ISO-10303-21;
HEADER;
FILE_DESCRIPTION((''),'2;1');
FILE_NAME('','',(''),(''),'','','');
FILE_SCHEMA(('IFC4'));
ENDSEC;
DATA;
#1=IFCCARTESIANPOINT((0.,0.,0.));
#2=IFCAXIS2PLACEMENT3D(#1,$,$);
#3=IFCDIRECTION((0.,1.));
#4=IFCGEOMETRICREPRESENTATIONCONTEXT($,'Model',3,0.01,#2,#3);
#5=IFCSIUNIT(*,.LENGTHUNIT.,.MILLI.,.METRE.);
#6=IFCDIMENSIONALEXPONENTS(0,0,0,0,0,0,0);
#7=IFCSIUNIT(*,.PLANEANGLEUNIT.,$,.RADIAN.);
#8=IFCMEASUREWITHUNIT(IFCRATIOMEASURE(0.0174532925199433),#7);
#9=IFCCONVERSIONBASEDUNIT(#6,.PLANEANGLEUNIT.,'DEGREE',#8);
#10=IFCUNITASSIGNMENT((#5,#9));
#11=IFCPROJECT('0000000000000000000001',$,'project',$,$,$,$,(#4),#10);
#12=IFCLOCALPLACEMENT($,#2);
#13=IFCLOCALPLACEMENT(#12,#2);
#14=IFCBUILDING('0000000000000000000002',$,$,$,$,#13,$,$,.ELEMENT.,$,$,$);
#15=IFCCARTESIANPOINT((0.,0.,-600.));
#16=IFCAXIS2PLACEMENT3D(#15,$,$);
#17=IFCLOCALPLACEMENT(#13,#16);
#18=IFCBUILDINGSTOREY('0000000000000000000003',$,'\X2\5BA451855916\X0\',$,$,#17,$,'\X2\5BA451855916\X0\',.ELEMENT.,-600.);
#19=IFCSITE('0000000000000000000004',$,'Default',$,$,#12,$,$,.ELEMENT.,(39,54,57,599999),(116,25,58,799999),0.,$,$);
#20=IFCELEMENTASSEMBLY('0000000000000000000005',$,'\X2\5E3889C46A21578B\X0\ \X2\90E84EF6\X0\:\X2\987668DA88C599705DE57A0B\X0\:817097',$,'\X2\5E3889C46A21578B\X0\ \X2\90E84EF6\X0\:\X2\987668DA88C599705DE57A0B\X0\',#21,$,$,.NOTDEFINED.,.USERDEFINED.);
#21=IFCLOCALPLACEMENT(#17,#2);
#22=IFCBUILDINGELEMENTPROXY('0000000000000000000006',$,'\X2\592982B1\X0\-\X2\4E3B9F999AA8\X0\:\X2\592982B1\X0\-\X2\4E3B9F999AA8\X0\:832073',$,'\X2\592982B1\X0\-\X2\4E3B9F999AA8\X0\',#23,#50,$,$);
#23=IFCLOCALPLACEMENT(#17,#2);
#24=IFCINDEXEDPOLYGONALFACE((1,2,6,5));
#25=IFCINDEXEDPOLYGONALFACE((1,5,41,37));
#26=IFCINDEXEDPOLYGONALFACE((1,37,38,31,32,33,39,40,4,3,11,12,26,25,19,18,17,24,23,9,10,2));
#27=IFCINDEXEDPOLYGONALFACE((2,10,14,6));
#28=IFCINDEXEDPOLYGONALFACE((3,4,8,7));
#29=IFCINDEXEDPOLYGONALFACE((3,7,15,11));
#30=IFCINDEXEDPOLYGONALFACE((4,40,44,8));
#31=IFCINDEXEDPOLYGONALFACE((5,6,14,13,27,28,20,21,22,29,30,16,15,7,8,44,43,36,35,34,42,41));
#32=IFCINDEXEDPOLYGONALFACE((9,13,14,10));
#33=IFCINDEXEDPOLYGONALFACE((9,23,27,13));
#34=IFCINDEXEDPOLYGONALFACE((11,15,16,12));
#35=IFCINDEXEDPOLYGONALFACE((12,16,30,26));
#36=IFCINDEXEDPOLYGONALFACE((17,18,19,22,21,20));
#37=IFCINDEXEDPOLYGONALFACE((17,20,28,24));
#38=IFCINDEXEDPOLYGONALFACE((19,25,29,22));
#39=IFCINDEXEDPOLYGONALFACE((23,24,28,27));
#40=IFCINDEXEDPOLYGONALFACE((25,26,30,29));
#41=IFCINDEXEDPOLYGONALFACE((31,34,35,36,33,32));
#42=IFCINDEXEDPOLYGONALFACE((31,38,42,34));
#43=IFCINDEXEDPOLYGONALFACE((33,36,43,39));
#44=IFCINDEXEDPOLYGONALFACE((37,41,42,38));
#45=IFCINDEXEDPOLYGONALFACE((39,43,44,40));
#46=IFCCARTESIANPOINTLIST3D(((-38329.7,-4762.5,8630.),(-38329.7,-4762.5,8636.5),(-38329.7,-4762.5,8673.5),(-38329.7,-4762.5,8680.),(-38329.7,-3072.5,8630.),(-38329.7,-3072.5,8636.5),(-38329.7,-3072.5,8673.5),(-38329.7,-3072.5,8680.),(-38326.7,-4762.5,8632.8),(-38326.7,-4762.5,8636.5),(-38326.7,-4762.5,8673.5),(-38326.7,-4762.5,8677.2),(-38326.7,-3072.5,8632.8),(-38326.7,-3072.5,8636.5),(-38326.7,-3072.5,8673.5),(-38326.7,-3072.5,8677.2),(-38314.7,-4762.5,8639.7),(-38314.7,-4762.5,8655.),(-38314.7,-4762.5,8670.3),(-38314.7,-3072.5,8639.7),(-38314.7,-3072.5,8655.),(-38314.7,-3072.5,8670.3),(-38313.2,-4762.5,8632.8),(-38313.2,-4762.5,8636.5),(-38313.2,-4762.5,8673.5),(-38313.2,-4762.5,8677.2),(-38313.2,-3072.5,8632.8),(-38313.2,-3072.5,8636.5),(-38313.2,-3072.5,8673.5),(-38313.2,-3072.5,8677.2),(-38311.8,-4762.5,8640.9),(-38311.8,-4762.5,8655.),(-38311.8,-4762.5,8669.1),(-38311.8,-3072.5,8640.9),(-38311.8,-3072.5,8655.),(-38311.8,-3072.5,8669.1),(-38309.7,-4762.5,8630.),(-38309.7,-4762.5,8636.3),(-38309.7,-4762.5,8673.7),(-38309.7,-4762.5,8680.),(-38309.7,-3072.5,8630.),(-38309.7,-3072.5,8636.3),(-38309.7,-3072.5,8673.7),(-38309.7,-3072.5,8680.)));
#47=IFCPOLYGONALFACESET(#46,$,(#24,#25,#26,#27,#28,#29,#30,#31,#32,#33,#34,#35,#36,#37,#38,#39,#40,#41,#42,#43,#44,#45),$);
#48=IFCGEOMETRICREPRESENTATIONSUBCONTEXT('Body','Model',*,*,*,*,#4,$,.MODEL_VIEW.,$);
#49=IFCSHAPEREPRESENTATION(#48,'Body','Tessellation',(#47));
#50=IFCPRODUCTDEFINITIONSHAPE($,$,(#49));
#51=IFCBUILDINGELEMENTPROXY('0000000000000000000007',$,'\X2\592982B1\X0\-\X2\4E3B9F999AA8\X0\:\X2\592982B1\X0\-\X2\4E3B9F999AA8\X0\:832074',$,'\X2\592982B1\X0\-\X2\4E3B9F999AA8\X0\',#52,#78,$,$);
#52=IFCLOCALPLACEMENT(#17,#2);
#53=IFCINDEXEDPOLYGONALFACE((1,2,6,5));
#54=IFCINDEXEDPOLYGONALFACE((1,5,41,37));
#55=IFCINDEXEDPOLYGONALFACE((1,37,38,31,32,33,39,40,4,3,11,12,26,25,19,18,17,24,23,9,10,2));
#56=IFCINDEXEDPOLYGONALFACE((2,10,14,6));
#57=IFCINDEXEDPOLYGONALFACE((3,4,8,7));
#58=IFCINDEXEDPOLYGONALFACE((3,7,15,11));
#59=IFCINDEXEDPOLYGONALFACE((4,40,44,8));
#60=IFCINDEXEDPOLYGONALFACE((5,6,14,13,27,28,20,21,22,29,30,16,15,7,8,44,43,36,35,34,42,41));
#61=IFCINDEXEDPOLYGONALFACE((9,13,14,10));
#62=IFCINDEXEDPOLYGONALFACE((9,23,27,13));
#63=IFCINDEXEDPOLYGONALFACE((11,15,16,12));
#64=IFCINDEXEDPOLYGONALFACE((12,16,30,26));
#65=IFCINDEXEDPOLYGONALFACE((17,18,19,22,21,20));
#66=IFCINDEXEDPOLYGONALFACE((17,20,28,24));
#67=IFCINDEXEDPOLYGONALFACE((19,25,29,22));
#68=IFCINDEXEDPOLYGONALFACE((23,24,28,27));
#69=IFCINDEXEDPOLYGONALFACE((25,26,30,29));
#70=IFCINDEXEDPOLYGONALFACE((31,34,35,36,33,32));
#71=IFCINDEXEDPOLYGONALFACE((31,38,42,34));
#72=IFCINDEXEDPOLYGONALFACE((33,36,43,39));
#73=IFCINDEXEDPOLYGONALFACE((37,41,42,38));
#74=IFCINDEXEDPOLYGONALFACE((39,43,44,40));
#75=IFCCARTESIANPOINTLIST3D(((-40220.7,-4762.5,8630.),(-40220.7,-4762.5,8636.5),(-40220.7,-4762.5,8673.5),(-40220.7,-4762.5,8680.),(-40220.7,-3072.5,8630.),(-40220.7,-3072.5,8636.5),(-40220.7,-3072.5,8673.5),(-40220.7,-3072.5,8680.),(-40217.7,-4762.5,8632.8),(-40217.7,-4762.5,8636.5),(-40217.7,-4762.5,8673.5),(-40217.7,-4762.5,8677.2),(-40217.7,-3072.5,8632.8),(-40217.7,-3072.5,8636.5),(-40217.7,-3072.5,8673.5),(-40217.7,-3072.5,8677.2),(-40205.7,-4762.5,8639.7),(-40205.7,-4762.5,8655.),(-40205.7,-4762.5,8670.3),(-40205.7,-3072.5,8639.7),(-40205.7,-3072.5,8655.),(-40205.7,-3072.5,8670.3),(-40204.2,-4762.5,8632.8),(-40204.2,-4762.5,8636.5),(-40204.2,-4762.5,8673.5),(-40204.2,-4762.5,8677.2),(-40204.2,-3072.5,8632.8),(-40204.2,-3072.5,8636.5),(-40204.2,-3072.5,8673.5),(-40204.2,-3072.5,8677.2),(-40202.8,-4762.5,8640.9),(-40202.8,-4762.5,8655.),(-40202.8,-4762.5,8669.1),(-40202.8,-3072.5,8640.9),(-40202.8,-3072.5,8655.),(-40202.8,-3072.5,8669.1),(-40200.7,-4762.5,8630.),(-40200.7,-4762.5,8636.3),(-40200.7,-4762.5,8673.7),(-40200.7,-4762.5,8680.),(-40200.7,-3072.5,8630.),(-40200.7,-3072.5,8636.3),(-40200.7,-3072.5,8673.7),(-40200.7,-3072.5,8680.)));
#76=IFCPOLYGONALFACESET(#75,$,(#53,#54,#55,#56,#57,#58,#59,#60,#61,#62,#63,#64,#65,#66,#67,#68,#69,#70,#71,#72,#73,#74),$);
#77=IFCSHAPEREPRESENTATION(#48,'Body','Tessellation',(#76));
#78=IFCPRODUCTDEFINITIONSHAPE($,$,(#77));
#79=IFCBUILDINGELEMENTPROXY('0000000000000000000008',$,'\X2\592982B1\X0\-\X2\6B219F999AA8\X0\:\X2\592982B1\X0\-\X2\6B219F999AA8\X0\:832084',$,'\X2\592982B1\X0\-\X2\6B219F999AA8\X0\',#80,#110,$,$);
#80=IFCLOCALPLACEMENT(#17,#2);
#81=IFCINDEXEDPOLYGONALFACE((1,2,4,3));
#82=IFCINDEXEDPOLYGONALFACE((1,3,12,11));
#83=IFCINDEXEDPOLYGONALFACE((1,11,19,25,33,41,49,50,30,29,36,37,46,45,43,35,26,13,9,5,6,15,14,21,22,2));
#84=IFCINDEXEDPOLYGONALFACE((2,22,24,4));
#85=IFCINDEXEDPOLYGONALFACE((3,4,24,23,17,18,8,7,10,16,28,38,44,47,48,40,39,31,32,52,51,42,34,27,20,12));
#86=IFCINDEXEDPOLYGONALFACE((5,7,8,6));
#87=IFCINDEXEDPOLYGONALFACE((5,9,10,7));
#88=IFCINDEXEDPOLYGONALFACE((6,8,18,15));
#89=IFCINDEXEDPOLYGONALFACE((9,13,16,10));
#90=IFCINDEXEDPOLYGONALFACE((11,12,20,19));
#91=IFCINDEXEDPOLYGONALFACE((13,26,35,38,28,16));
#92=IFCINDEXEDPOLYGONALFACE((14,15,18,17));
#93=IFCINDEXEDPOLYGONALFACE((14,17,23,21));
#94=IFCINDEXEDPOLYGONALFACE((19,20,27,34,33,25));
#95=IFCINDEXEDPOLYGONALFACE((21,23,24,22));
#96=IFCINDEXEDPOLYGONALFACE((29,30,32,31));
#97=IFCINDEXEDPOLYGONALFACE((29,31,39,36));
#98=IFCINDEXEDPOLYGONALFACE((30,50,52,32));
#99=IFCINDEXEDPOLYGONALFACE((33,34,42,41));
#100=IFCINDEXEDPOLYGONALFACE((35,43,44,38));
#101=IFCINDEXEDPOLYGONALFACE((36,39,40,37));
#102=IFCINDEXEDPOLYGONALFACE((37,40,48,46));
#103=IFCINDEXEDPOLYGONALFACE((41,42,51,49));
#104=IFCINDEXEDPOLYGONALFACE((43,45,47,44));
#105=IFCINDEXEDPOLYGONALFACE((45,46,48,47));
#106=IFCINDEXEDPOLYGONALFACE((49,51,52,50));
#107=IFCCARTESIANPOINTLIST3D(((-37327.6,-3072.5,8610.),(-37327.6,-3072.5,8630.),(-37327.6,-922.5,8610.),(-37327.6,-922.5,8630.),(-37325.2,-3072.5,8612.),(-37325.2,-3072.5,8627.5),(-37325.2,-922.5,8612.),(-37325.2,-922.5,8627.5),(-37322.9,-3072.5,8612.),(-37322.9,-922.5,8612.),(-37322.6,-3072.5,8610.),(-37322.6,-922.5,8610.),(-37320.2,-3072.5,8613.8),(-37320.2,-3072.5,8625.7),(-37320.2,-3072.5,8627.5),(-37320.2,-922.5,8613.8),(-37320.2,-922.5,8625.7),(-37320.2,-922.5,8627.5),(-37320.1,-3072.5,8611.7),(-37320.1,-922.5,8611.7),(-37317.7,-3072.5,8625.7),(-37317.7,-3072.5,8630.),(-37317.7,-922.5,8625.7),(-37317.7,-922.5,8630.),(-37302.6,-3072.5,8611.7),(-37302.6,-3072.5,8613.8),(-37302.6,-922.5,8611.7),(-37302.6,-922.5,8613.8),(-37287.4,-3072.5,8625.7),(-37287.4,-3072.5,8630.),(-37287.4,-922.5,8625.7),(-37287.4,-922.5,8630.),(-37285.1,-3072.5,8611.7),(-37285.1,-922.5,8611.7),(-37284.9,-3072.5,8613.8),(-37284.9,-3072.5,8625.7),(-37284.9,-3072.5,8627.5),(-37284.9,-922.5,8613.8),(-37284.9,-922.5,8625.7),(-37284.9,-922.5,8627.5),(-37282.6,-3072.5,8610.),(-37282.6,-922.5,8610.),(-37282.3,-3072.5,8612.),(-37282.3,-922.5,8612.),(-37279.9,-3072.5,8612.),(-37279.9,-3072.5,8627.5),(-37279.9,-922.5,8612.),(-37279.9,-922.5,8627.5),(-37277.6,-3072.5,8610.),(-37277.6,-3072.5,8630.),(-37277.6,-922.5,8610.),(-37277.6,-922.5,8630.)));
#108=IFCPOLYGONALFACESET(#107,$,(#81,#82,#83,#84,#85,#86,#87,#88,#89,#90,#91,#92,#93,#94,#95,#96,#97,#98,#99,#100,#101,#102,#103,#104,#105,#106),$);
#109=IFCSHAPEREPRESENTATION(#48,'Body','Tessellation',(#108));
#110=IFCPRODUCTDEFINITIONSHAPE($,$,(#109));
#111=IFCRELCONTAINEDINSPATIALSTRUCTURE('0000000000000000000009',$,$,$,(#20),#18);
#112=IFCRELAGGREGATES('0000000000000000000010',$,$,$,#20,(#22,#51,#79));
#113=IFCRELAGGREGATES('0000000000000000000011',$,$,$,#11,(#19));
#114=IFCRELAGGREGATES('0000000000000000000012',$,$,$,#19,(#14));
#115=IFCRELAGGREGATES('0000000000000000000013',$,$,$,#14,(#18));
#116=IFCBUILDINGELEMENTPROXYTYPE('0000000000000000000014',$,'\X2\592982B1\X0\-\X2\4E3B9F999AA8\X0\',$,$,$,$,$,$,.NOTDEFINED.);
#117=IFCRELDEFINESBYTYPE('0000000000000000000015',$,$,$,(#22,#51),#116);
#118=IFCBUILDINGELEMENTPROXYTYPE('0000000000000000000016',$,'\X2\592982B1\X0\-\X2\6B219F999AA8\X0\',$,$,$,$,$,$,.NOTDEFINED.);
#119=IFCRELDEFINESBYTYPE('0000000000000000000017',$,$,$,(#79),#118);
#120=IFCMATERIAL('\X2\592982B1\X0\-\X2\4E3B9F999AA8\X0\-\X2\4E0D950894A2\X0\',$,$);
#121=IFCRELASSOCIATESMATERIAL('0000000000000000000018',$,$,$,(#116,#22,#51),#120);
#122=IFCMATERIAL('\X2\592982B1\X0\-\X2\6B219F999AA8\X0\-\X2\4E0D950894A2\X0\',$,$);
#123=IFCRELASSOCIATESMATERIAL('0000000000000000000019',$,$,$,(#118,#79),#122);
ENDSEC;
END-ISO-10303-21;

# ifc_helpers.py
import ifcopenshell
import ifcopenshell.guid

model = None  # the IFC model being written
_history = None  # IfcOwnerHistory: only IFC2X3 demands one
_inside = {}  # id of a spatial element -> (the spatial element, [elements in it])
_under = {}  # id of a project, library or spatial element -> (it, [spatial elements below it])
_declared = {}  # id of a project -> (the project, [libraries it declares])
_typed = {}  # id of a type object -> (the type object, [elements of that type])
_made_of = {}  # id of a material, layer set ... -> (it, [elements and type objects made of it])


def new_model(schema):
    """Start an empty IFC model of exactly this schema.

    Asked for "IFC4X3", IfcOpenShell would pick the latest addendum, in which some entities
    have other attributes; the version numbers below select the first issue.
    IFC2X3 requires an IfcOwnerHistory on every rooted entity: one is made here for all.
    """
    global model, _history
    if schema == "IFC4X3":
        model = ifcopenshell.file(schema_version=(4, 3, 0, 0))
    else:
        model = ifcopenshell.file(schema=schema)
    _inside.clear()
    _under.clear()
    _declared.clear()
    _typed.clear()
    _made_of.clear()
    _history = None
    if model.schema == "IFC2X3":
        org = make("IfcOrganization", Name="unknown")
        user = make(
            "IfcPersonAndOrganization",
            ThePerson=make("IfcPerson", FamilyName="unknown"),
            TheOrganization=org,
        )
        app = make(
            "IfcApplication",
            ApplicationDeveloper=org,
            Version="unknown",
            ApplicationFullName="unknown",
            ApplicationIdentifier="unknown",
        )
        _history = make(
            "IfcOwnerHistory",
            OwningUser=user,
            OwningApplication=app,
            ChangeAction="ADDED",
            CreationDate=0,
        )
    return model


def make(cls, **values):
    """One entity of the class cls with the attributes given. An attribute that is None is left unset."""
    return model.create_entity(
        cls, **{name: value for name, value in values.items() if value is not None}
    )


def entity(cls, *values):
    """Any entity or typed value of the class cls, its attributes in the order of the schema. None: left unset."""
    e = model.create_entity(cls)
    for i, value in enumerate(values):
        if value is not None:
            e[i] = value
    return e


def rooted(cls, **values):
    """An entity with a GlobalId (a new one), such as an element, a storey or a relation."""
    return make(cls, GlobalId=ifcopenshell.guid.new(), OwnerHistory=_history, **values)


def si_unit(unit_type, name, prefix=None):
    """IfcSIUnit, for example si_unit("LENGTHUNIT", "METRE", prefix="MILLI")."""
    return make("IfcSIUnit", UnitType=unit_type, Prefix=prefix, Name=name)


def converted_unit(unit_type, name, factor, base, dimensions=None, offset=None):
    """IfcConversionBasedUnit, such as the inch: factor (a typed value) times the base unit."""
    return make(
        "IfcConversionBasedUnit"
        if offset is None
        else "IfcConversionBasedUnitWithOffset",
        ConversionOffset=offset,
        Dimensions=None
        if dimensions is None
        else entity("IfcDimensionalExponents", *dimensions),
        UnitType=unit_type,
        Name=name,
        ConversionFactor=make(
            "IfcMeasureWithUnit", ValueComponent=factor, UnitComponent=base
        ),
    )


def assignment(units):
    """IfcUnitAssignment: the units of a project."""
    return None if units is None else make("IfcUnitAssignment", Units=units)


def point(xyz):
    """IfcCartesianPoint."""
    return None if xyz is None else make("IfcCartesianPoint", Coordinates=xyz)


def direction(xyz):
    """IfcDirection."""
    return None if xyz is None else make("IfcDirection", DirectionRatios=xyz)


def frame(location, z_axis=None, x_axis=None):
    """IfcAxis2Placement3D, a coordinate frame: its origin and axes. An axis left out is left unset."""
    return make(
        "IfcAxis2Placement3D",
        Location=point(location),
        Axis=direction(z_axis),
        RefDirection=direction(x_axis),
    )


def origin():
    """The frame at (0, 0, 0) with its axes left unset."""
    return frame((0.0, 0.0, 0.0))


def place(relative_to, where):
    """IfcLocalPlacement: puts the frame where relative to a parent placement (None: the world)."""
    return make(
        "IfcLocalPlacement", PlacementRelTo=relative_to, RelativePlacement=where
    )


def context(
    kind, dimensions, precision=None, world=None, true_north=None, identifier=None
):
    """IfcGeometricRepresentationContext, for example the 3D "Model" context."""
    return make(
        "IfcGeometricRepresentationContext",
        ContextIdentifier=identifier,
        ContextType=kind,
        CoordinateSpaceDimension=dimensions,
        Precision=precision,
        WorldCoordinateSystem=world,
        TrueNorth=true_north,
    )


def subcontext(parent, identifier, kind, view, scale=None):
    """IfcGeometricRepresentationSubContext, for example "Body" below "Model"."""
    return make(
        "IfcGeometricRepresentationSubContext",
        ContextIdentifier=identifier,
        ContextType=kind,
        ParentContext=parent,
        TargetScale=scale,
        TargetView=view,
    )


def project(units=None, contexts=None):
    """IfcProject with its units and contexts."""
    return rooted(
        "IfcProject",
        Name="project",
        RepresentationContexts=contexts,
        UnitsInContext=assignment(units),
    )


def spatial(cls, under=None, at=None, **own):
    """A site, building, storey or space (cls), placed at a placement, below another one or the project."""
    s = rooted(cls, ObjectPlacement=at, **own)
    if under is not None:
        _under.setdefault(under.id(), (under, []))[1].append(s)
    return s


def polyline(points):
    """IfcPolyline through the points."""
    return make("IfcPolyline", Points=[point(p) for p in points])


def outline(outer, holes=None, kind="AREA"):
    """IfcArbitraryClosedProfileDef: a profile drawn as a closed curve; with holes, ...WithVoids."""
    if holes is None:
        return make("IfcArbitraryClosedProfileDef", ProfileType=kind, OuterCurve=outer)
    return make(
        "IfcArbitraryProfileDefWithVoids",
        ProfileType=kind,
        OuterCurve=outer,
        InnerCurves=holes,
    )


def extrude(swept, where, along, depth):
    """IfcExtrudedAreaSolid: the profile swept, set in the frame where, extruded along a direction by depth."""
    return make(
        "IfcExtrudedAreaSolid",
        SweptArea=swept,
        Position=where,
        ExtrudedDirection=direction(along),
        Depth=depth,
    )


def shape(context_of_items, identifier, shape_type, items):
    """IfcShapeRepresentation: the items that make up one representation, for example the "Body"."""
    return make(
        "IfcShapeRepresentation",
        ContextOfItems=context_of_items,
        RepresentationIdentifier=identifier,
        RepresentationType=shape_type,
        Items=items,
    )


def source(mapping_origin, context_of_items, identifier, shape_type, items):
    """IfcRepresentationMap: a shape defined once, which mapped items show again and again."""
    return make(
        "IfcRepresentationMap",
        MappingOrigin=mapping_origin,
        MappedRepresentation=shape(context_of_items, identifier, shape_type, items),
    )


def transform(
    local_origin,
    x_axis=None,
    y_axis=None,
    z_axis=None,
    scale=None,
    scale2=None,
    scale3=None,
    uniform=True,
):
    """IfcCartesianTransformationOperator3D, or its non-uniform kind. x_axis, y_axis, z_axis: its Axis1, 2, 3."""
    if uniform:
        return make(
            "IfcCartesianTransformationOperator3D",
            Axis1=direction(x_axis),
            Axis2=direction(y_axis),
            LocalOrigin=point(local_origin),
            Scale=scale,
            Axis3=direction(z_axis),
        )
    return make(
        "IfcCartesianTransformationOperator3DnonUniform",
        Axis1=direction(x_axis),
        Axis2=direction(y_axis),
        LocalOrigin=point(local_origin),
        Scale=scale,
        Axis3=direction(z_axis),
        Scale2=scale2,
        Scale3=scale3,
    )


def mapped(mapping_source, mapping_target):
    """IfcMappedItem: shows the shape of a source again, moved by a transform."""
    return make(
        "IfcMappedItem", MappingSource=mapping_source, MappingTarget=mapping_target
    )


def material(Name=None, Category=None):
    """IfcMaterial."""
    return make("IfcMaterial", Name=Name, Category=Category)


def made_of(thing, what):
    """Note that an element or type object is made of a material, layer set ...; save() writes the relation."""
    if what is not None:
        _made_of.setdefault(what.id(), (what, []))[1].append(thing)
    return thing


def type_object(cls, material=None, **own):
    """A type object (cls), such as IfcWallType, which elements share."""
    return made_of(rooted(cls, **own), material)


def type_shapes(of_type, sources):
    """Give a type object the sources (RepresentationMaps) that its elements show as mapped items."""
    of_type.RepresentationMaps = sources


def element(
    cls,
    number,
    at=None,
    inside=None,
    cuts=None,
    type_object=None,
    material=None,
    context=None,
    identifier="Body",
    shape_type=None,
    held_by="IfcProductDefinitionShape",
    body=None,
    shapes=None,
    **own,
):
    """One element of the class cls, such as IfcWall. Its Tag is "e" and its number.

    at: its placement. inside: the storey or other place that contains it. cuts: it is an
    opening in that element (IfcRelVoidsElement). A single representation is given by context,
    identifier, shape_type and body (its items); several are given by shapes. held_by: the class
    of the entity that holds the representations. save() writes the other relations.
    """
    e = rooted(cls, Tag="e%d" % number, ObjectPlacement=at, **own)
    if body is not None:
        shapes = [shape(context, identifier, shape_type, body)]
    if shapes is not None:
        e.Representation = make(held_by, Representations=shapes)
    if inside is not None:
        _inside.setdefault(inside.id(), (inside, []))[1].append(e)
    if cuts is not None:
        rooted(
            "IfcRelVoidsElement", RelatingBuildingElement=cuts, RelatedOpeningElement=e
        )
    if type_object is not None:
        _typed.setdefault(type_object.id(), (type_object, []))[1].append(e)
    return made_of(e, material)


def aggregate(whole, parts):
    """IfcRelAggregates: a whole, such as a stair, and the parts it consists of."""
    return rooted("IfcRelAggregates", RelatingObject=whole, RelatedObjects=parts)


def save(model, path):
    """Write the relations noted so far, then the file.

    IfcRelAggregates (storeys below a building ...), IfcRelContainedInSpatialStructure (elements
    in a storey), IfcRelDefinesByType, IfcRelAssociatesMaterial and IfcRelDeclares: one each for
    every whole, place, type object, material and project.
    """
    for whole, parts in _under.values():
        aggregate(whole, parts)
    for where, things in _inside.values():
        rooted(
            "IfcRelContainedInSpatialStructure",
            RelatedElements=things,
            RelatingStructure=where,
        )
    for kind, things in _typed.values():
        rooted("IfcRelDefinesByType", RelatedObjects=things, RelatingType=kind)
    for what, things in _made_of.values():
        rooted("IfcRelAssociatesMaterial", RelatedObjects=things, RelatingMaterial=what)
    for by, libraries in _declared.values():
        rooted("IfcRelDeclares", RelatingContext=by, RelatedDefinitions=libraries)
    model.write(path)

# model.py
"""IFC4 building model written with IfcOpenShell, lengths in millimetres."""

from ifc_helpers import new_model, entity, si_unit, converted_unit, direction, frame, origin, place, context, subcontext, project, spatial, polyline, outline, extrude, source, transform, mapped, material, type_object, type_shapes, element, aggregate, save


model = new_model("IFC4")

# Units and contexts
model_context = context("Model", 3, precision=0.01, world=origin(), true_north=direction((0.0, 1.0)))
body_context = subcontext(model_context, "Body", "Model", "MODEL_VIEW")
ifc_project = project(units=[si_unit("LENGTHUNIT", "METRE", prefix="MILLI"), converted_unit("PLANEANGLEUNIT", "DEGREE", entity("IfcRatioMeasure", 0.0174532925199433), si_unit("PLANEANGLEUNIT", "RADIAN"), dimensions=[0, 0, 0, 0, 0, 0, 0])], contexts=[model_context])

# Site, building, storey
site_placement = place(None, origin())
site = spatial("IfcSite", under=ifc_project, at=site_placement, Name="Default", CompositionType="ELEMENT", RefLatitude=(39, 54, 57, 599999), RefLongitude=(116, 25, 58, 799999), RefElevation=0.0)
building_placement = place(site_placement, origin())
building = spatial("IfcBuilding", under=site, at=building_placement, CompositionType="ELEMENT")
storey_placement = place(building_placement, frame((0.0, 0.0, -600.0)))
storey = spatial("IfcBuildingStorey", under=building, at=storey_placement, Name="室内外", LongName="室内外", CompositionType="ELEMENT", Elevation=-600.0)

# Element assembly
assembly_1_placement = place(storey_placement, origin())
assembly_1 = element("IfcElementAssembly", 1, at=assembly_1_placement, inside=storey, Name="常规模型 部件:顶棚装饰工程:817097", ObjectType="常规模型 部件:顶棚装饰工程", AssemblyPlace="NOTDEFINED", PredefinedType="USERDEFINED")

# Building element proxies
ifc_material_1 = material(Name="天花-次龙骨-不锈钢")
ifc_material_2 = material(Name="天花-主龙骨-不锈钢")
building_element_proxy_type_1 = type_object("IfcBuildingElementProxyType", Name="天花-主龙骨", PredefinedType="NOTDEFINED", material=ifc_material_2)
shared_shape_1 = source(origin(), body_context, "Body", "SweptSolid", [
    extrude(outline(polyline([(-25.0, -11.7), (-18.5, -11.7), (-18.5, -8.7), (-22.2, -8.7), (-22.2, 4.8), (-18.5, 4.8), (-15.3, 3.3), (0.0, 3.3), (15.3, 3.3), (18.5, 4.8), (22.2, 4.8), (22.2, -8.7), (18.5, -8.7), (18.5, -11.7), (25.0, -11.7), (25.0, 8.3), (18.7, 8.3), (14.1, 6.2), (0.0, 6.2), (-14.1, 6.2), (-18.7, 8.3), (-25.0, 8.3), (-25.0, -11.7)])), frame((0.0, 1.7, 0.0), z_axis=(1.0, 0.0, 0.0), x_axis=(0.0, 0.0, -1.0)), (0.0, 0.0, 1.0), 1690.0),
])
type_shapes(building_element_proxy_type_1, [shared_shape_1])
proxy_1_placement = place(assembly_1_placement, frame((-38319.7, -3072.5, 8655.0), z_axis=(0.0, 0.0, 1.0), x_axis=(0.0, -1.0, 0.0)))
proxy_1 = element("IfcBuildingElementProxy", 2, at=proxy_1_placement, type_object=building_element_proxy_type_1, material=ifc_material_2, Name="天花-主龙骨:天花-主龙骨:832073", ObjectType="天花-主龙骨", context=body_context, shape_type="MappedRepresentation", body=[
    mapped(shared_shape_1, transform((0.0, 0.0, 0.0), scale=1.0)),
])
proxy_2_placement = place(assembly_1_placement, frame((-40210.7, -3072.5, 8655.0), z_axis=(0.0, 0.0, 1.0), x_axis=(0.0, -1.0, 0.0)))
proxy_2 = element("IfcBuildingElementProxy", 3, at=proxy_2_placement, type_object=building_element_proxy_type_1, material=ifc_material_2, Name="天花-主龙骨:天花-主龙骨:832074", ObjectType="天花-主龙骨", context=body_context, shape_type="MappedRepresentation", body=[
    mapped(shared_shape_1, transform((0.0, 0.0, 0.0), scale=1.0)),
])
building_element_proxy_type_2 = type_object("IfcBuildingElementProxyType", Name="天花-次龙骨", PredefinedType="NOTDEFINED", material=ifc_material_1)
shared_shape_2 = source(origin(), body_context, "Body", "SweptSolid", [
    extrude(outline(polyline([(-25.0, -9.1), (-20.0, -9.1), (-17.5, -7.4), (0.0, -7.4), (17.5, -7.4), (20.0, -9.1), (25.0, -9.1), (25.0, 10.9), (15.1, 10.9), (15.1, 6.6), (17.6, 6.6), (17.6, 8.4), (22.6, 8.4), (22.6, -7.1), (20.3, -7.1), (17.6, -5.3), (0.0, -5.3), (-17.6, -5.3), (-20.3, -7.1), (-22.6, -7.1), (-22.6, 8.4), (-17.6, 8.4), (-17.6, 6.6), (-15.1, 6.6), (-15.1, 10.9), (-25.0, 10.9), (-25.0, -9.1)])), frame((0.0, 0.0, -0.9), z_axis=(1.0, 0.0, 0.0), x_axis=(0.0, 1.0, 0.0)), (0.0, 0.0, 1.0), 2150.0),
])
type_shapes(building_element_proxy_type_2, [shared_shape_2])
proxy_3_placement = place(assembly_1_placement, frame((-37302.6, -922.5, 8620.0), z_axis=(0.0, 0.0, 1.0), x_axis=(0.0, -1.0, 0.0)))
proxy_3 = element("IfcBuildingElementProxy", 4, at=proxy_3_placement, type_object=building_element_proxy_type_2, material=ifc_material_1, Name="天花-次龙骨:天花-次龙骨:832084", ObjectType="天花-次龙骨", context=body_context, shape_type="MappedRepresentation", body=[
    mapped(shared_shape_2, transform((0.0, 0.0, 0.0), scale=1.0)),
])
aggregate(assembly_1, [proxy_1, proxy_2, proxy_3])

save(model, "model.ifc")
